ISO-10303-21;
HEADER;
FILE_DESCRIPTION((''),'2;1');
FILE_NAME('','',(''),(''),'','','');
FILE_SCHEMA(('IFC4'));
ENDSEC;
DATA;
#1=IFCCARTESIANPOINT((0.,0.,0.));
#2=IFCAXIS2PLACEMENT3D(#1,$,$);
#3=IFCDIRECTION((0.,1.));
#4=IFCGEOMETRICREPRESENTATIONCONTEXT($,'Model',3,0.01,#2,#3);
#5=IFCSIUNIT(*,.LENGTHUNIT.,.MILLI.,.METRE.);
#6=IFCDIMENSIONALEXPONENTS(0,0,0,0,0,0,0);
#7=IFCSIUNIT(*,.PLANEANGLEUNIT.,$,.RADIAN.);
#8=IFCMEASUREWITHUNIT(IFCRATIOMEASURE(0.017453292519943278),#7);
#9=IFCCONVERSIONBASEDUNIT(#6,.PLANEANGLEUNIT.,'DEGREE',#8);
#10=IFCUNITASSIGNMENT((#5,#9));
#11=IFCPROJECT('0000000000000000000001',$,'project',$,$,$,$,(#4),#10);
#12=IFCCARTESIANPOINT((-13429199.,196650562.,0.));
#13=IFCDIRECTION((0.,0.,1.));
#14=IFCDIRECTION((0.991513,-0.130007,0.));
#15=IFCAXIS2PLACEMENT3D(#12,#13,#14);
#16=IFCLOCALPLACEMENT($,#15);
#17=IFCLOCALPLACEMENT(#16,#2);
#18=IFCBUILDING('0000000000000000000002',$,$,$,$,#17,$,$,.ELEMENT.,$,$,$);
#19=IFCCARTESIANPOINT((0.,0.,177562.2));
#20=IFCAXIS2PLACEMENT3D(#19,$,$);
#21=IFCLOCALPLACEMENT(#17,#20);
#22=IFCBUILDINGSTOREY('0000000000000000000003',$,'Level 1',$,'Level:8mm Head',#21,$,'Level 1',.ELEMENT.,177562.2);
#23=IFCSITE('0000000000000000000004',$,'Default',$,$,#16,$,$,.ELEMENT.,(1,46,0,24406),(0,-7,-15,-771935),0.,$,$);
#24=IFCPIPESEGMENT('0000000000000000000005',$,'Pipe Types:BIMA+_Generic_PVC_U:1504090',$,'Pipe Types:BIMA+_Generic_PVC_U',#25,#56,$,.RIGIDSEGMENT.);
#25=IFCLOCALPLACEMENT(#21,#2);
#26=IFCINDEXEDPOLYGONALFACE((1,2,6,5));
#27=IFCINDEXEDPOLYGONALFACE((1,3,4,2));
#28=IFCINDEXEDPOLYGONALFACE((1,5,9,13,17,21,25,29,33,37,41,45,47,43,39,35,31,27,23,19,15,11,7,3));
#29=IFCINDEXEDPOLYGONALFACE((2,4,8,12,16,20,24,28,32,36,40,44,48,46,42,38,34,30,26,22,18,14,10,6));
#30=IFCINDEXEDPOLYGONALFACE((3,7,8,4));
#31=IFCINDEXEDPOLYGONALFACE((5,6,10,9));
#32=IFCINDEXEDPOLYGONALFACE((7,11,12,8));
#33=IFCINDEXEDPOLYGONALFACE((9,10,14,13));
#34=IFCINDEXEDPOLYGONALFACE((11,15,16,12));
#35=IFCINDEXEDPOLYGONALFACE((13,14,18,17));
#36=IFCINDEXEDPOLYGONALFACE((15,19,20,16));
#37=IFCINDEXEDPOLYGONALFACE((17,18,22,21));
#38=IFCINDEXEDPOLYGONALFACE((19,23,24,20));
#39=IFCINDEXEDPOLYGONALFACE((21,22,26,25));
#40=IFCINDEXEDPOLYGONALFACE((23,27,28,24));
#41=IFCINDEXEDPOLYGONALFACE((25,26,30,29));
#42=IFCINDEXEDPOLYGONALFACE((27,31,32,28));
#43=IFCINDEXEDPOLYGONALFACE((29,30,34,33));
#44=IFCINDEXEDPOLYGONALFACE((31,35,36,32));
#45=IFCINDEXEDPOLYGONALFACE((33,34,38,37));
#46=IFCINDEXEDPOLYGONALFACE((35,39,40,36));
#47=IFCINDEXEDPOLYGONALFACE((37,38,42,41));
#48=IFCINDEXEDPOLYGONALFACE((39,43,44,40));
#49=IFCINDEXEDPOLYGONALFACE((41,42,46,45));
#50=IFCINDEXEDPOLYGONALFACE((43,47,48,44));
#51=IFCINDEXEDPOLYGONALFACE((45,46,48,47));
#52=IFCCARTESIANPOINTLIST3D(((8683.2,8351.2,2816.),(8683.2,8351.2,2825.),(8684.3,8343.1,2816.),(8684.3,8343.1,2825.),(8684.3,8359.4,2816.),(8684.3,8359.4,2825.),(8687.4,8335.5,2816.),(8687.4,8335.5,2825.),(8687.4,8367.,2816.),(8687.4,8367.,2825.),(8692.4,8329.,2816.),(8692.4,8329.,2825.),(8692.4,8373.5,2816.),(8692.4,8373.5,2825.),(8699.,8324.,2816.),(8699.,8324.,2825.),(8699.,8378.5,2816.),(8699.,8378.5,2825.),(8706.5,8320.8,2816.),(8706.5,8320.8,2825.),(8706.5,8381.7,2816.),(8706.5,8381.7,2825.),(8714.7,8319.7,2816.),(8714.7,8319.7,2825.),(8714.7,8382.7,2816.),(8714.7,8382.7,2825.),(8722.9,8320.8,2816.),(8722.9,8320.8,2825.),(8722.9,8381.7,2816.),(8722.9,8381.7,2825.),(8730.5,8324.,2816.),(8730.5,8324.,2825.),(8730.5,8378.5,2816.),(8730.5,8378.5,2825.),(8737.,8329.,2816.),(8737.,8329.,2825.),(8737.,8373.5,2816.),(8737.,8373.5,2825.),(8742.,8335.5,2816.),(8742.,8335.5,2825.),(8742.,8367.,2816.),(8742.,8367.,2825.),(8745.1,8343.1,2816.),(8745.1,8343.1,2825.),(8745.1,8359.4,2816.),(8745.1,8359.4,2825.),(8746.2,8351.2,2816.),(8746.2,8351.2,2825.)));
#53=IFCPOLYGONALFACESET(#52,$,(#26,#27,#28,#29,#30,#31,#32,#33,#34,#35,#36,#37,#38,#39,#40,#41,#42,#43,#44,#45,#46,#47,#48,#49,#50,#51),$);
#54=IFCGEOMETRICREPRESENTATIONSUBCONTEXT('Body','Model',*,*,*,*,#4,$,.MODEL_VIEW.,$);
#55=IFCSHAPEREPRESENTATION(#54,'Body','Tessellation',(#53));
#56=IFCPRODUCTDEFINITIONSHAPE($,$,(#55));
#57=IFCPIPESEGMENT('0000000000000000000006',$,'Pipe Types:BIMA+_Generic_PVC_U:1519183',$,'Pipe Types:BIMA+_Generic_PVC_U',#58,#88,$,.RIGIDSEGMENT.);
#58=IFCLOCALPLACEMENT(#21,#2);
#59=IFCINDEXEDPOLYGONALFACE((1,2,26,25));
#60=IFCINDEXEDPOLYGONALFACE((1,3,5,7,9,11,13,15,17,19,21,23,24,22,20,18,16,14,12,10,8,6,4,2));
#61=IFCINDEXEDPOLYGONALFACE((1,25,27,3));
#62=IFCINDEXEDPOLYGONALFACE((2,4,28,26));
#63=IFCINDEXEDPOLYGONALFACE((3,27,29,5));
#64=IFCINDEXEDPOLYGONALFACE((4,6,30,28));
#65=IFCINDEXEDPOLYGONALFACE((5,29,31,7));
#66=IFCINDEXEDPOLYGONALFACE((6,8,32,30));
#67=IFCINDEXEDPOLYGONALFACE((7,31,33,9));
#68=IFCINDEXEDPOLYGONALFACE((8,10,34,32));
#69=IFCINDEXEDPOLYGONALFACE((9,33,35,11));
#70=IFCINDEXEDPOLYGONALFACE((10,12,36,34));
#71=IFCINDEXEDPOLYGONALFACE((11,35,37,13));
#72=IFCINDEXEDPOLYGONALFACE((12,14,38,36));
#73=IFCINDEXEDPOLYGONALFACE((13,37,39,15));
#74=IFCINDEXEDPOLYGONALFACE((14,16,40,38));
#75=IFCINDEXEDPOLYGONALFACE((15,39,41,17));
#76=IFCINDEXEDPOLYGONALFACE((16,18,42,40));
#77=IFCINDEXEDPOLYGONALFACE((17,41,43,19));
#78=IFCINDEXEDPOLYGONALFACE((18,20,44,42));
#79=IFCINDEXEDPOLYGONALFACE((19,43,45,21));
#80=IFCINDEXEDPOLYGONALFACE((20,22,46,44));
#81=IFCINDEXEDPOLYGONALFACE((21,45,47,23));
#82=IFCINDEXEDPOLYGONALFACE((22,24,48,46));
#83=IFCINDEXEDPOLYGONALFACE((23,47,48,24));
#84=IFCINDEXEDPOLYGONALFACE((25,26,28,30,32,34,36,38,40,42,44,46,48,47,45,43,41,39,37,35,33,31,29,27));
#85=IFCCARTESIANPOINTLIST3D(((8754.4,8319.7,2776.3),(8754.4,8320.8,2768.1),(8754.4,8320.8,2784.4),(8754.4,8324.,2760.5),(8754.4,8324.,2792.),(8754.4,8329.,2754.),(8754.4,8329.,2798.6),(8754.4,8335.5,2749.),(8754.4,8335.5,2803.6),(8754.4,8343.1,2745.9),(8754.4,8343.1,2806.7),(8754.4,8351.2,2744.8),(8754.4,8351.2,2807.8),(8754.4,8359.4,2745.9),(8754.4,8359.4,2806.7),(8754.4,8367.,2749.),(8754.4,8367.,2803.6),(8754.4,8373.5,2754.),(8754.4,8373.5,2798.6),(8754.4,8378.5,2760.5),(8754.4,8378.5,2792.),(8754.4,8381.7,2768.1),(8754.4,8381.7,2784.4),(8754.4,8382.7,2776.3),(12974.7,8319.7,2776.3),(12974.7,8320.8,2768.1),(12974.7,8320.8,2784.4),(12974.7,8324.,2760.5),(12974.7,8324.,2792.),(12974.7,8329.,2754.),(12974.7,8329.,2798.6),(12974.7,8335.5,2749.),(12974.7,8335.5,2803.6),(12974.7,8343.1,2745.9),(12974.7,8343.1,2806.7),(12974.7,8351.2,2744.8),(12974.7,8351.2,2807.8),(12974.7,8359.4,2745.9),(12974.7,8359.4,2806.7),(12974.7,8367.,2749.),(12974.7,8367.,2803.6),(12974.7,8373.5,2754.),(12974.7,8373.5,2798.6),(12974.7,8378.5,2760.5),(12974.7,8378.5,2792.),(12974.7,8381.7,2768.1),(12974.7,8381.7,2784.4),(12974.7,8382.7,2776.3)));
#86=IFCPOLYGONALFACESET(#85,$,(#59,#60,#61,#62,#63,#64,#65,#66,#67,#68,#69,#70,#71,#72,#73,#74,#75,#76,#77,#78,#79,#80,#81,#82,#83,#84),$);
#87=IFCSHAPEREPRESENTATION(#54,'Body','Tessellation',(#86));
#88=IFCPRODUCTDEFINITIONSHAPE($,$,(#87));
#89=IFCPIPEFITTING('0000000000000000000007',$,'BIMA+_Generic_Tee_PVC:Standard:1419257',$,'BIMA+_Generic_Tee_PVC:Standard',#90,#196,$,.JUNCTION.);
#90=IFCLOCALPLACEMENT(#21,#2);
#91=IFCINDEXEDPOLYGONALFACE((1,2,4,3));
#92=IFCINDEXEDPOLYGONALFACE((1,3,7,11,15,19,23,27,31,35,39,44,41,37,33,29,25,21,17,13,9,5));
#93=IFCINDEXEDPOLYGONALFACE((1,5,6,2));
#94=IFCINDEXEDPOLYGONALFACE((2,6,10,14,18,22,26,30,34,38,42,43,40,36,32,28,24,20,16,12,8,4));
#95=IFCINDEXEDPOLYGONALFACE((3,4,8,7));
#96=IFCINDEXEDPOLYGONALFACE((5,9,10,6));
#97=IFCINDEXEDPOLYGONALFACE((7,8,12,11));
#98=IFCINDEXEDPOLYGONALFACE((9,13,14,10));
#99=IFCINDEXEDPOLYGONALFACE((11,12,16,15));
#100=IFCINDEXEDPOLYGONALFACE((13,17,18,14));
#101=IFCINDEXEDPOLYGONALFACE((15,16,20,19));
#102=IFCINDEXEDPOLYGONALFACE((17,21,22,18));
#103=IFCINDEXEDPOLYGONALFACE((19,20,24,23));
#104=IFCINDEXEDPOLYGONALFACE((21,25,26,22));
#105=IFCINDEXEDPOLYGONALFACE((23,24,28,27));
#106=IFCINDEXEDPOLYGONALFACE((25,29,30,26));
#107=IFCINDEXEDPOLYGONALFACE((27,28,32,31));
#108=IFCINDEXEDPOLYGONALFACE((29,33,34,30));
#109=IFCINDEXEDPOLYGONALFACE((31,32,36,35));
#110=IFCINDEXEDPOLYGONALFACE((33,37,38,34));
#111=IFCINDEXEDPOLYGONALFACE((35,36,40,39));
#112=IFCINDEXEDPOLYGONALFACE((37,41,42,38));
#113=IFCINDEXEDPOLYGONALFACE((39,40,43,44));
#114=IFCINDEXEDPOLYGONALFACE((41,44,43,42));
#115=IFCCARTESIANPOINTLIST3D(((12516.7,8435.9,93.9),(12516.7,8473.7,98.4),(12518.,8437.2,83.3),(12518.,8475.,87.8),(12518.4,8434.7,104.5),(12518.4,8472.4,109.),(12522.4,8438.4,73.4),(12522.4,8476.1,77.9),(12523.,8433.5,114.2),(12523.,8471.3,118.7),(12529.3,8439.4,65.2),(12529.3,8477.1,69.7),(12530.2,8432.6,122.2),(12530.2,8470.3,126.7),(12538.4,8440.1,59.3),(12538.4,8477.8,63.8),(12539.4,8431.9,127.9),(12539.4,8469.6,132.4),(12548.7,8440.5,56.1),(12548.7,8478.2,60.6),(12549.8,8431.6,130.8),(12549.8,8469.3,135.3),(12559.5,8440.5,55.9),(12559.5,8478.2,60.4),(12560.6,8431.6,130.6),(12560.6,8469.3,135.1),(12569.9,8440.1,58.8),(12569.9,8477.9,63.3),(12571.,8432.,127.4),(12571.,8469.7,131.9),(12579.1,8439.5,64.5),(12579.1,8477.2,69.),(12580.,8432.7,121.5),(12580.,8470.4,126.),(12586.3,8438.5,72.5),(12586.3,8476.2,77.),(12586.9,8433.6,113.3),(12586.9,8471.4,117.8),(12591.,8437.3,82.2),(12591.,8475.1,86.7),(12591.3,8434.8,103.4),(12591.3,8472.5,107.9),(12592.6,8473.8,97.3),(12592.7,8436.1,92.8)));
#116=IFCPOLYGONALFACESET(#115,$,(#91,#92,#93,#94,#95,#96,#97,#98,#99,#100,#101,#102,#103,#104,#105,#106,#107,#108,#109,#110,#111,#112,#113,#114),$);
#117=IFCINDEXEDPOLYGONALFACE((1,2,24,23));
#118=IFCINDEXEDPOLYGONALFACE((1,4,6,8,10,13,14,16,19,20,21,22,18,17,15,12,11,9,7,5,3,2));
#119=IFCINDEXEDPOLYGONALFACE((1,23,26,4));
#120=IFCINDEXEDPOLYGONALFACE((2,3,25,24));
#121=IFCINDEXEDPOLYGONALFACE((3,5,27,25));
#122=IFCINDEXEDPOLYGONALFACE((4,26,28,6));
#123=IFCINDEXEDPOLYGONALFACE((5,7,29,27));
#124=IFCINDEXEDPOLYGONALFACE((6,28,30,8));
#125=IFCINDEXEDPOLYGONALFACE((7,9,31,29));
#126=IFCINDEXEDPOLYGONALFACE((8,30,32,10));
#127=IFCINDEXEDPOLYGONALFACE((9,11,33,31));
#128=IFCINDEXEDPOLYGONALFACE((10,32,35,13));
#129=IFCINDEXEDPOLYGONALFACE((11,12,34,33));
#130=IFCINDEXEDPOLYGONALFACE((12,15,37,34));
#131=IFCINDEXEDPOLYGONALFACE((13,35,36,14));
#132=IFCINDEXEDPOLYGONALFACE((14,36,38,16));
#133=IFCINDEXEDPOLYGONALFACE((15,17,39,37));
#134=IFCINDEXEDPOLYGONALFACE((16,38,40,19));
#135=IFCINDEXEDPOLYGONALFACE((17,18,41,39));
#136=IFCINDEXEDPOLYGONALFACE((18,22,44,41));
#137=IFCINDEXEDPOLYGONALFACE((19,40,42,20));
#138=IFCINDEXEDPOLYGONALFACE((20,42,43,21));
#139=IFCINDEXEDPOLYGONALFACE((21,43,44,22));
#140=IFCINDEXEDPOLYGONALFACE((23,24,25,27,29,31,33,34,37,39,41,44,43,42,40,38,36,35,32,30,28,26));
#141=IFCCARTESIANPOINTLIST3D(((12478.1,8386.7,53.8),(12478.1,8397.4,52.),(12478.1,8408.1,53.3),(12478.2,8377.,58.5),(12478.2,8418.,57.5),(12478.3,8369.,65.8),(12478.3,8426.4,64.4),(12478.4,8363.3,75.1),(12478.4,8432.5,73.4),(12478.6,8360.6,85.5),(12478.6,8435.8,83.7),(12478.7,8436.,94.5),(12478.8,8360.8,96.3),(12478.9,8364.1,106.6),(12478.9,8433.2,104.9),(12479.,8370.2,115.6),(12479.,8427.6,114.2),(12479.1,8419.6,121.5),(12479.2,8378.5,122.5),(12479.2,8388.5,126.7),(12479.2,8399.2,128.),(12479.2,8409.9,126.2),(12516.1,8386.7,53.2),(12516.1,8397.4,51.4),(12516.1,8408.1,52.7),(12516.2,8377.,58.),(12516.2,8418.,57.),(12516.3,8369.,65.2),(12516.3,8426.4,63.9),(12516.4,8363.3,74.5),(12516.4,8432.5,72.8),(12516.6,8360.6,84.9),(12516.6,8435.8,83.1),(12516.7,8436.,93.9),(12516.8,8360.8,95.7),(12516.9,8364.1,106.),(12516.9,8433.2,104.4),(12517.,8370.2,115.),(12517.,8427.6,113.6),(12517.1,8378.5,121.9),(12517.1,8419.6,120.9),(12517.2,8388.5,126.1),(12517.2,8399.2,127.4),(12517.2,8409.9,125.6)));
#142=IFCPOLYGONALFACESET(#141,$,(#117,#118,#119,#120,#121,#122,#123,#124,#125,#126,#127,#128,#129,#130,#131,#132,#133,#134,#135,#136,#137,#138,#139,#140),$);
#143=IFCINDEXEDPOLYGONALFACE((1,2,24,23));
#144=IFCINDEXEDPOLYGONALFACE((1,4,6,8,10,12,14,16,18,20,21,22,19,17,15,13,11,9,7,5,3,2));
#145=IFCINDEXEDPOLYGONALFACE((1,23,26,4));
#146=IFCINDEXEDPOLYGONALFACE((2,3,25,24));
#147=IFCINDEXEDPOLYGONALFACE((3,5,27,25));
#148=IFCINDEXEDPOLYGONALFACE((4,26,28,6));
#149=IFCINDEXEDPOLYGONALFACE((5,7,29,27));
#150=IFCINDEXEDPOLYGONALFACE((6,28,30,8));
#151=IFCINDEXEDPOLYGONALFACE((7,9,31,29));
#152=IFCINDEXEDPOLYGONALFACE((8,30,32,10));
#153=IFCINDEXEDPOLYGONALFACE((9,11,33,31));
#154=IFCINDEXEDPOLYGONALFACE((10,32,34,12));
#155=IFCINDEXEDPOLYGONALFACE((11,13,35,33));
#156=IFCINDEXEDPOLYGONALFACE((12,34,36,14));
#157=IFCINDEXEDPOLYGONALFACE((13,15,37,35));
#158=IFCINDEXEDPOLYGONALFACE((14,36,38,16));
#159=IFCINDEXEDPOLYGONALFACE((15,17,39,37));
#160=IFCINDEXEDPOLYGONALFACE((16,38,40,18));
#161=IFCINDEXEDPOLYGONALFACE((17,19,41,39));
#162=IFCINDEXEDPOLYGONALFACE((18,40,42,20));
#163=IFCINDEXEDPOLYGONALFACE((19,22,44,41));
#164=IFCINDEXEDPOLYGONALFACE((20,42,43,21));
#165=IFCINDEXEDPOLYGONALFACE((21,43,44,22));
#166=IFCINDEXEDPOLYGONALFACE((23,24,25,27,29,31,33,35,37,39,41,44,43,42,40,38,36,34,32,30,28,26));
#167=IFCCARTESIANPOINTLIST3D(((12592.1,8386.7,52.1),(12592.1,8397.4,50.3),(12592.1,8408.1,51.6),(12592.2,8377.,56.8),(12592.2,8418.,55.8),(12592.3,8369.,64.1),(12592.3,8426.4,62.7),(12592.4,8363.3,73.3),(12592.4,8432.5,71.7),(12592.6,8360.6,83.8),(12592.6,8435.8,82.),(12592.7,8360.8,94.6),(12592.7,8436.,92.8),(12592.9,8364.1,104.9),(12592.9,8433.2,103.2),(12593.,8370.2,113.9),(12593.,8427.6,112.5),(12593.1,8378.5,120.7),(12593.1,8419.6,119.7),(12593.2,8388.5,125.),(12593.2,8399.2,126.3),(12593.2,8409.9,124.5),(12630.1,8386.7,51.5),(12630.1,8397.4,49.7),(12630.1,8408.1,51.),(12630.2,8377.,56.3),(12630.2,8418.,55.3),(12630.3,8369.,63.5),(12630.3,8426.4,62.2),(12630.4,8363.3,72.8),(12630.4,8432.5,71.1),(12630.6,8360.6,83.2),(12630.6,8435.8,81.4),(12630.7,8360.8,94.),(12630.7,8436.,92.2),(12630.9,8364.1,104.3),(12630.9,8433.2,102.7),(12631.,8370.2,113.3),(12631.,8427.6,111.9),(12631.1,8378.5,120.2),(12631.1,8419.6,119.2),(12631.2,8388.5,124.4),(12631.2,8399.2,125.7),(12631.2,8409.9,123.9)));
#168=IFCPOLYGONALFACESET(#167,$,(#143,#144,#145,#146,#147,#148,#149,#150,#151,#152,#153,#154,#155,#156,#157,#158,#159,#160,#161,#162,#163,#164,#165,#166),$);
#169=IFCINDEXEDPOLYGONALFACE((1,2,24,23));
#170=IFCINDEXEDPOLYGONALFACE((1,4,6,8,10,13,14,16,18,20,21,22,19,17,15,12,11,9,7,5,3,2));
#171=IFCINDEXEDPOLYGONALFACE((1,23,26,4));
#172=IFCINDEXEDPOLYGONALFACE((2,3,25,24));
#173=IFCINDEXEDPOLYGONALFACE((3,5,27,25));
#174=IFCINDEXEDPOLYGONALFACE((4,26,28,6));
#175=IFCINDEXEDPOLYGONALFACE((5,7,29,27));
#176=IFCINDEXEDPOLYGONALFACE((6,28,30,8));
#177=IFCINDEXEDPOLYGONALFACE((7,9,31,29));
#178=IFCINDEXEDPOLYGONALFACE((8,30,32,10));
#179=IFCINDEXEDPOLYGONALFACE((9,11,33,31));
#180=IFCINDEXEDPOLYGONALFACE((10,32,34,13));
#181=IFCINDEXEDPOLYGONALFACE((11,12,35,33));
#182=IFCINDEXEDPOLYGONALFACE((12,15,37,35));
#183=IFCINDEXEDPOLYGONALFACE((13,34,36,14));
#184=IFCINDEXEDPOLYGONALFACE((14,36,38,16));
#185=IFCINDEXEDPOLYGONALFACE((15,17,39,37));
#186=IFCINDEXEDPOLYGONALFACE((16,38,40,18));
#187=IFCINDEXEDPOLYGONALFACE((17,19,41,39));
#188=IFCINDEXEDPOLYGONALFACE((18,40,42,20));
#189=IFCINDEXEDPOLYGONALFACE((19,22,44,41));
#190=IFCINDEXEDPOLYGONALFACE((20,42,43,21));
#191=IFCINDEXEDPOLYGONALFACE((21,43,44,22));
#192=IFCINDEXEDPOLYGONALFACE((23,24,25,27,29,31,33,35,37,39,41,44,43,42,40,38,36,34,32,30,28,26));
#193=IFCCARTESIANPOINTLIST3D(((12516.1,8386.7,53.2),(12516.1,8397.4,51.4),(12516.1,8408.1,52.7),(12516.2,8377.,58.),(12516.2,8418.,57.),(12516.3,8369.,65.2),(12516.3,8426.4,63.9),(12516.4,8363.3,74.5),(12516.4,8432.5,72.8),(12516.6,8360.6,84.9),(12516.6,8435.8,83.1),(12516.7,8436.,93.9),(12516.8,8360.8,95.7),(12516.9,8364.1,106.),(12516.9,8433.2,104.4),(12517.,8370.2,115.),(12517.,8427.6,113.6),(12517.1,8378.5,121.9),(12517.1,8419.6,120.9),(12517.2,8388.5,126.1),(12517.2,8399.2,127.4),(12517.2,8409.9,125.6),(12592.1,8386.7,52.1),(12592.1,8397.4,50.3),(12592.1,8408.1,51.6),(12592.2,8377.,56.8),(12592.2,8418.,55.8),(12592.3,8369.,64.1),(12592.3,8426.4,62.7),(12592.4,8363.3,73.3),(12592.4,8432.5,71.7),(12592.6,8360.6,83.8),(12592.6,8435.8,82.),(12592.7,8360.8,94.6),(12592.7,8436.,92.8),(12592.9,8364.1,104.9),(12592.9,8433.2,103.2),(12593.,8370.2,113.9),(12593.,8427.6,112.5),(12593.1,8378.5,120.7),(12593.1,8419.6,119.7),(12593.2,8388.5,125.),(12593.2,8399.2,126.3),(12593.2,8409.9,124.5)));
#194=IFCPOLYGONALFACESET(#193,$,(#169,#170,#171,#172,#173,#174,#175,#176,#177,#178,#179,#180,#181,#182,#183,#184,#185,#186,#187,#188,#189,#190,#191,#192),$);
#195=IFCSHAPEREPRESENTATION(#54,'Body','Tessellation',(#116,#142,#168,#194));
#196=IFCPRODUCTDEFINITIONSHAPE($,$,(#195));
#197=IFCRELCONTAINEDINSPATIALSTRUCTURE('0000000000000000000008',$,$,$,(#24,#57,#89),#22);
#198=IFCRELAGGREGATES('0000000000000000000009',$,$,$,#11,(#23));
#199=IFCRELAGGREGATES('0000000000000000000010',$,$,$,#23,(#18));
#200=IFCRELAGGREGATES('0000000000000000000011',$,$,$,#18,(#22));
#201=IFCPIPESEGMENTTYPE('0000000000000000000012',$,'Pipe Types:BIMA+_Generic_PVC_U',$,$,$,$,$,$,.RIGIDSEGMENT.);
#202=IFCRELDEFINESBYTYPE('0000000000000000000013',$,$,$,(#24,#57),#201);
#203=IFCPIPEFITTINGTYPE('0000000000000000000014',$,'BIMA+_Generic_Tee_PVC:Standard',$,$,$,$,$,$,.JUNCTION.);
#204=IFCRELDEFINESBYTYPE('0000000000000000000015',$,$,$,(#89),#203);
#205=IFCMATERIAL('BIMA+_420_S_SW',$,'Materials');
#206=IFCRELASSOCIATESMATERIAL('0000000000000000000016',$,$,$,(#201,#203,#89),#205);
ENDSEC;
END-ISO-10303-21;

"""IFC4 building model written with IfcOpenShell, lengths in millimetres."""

from ifc_helpers import new_model, entity, si_unit, converted_unit, direction, frame, origin, place, context, subcontext, project, spatial, arc, indexed_curve, outline, extrude, source, transform, mapped, material, type_object, type_shapes, element, save


model = new_model("IFC4")

# Units and contexts
model_context = context("Model", 3, precision=0.01, world=origin(), true_north=direction((0.0, 1.0)))
body_context = subcontext(model_context, "Body", "Model", "MODEL_VIEW")
ifc_project = project(units=[si_unit("LENGTHUNIT", "METRE", prefix="MILLI"), converted_unit("PLANEANGLEUNIT", "DEGREE", entity("IfcRatioMeasure", 0.017453292519943278), si_unit("PLANEANGLEUNIT", "RADIAN"), dimensions=[0, 0, 0, 0, 0, 0, 0])], contexts=[model_context])

# Site, building, storey
site_placement = place(None, frame((-13429199.0, 196650562.0, 0.0), z_axis=(0.0, 0.0, 1.0), x_axis=(0.991513, -0.130007, 0.0)))
site = spatial("IfcSite", under=ifc_project, at=site_placement, Name="Default", CompositionType="ELEMENT", RefLatitude=(1, 46, 0, 24406), RefLongitude=(0, -7, -15, -771935), RefElevation=0.0)
building_placement = place(site_placement, origin())
building = spatial("IfcBuilding", under=site, at=building_placement, CompositionType="ELEMENT")
storey_placement = place(building_placement, frame((0.0, 0.0, 177562.2)))
storey = spatial("IfcBuildingStorey", under=building, at=storey_placement, Name="Level 1", ObjectType="Level:8mm Head", LongName="Level 1", CompositionType="ELEMENT", Elevation=177562.2)

# Pipe segments
ifc_material_1 = material(Name="BIMA+_420_S_SW", Category="Materials")
pipe_segment_type_1 = type_object("IfcPipeSegmentType", Name="Pipe Types:BIMA+_Generic_PVC_U", PredefinedType="RIGIDSEGMENT", material=ifc_material_1)
pipe_segment_1_placement = place(storey_placement, frame((8681.6, 8318.2, 2825.0)))
element("IfcPipeSegment", 1, at=pipe_segment_1_placement, inside=storey, type_object=pipe_segment_type_1, Name="Pipe Types:BIMA+_Generic_PVC_U:1504090", ObjectType="Pipe Types:BIMA+_Generic_PVC_U", PredefinedType="RIGIDSEGMENT", context=body_context, shape_type="SweptSolid", body=[
    extrude(outline(indexed_curve([(31.5, 0.0), (22.3, 22.3), (0.0, 31.5), (-22.3, 22.3), (-31.5, 0.0), (-22.3, -22.3), (0.0, -31.5), (22.3, -22.3)], segments=[arc(1, 2, 3), arc(3, 4, 5), arc(5, 6, 7), arc(7, 8, 1)], self_intersect=False)), frame((33.1, 33.1, -9.0), z_axis=(0.0, 0.0, 1.0), x_axis=(-1.0, 0.0, 0.0)), (0.0, 0.0, 1.0), 9.0),
])
pipe_segment_2_placement = place(storey_placement, frame((8754.4, 8318.2, 2743.2)))
element("IfcPipeSegment", 2, at=pipe_segment_2_placement, inside=storey, type_object=pipe_segment_type_1, Name="Pipe Types:BIMA+_Generic_PVC_U:1519183", ObjectType="Pipe Types:BIMA+_Generic_PVC_U", PredefinedType="RIGIDSEGMENT", context=body_context, shape_type="SweptSolid", body=[
    extrude(outline(indexed_curve([(31.5, 0.0), (22.3, 22.3), (0.0, 31.5), (-22.3, 22.3), (-31.5, 0.0), (-22.3, -22.3), (0.0, -31.5), (22.3, -22.3)], segments=[arc(1, 2, 3), arc(3, 4, 5), arc(5, 6, 7), arc(7, 8, 1)], self_intersect=False)), frame((0.0, 33.1, 33.1), z_axis=(1.0, 0.0, 0.0), x_axis=(0.0, -1.0, 0.0)), (0.0, 0.0, 1.0), 4220.3),
])

# Pipe fitting
pipe_fitting_type = type_object("IfcPipeFittingType", Name="BIMA+_Generic_Tee_PVC:Standard", PredefinedType="JUNCTION", material=ifc_material_1)
shared_shape = source(origin(), body_context, "Body", "SweptSolid", [
    extrude(outline(indexed_curve([(-38.0, 0.0), (0.0, -38.0), (38.0, 0.0), (0.0, 38.0)], segments=[arc(1, 2, 3), arc(3, 4, 1)], self_intersect=False)), frame((0.1, -38.0, 0.0), z_axis=(0.001804, -0.999998, 0.0), x_axis=(-0.999998, -0.001804, 0.0)), (0.0, 0.0, 1.0), 38.0),
    extrude(outline(indexed_curve([(-38.0, 0.0), (0.0, -38.0), (38.0, 0.0), (0.0, 38.0)], segments=[arc(1, 2, 3), arc(3, 4, 1)], self_intersect=False)), frame((38.0, 0.0, 0.0), z_axis=(1.0, 0.0, 0.0), x_axis=(0.0, 1.0, 0.0)), (0.0, 0.0, 1.0), 38.0),
    extrude(outline(indexed_curve([(-38.0, 0.0), (0.0, -38.0), (38.0, 0.0), (0.0, 38.0)], segments=[arc(1, 2, 3), arc(3, 4, 1)], self_intersect=False)), frame((-76.0, 0.0, 0.0), z_axis=(1.0, 0.0, 0.0), x_axis=(0.0, 1.0, 0.0)), (0.0, 0.0, 1.0), 38.0),
    extrude(outline(indexed_curve([(-38.0, 0.0), (0.0, -38.0), (38.0, 0.0), (0.0, 38.0)], segments=[arc(1, 2, 3), arc(3, 4, 1)], self_intersect=False)), frame((-38.0, 0.0, 0.0), z_axis=(1.0, 0.0, 0.0), x_axis=(0.0, 1.0, 0.0)), (0.0, 0.0, 1.0), 76.0),
])
type_shapes(pipe_fitting_type, [shared_shape])
pipe_fitting_placement = place(storey_placement, frame((12554.7, 8398.3, 88.9), z_axis=(0.014893, -0.118377, 0.992857), x_axis=(-0.999888, 0.0, 0.014998)))
element("IfcPipeFitting", 3, at=pipe_fitting_placement, inside=storey, type_object=pipe_fitting_type, material=ifc_material_1, Name="BIMA+_Generic_Tee_PVC:Standard:1419257", ObjectType="BIMA+_Generic_Tee_PVC:Standard", PredefinedType="JUNCTION", context=body_context, shape_type="MappedRepresentation", body=[
    mapped(shared_shape, transform((0.0, 0.0, 0.0), scale=1.0)),
])

save(model, "model.ifc")
